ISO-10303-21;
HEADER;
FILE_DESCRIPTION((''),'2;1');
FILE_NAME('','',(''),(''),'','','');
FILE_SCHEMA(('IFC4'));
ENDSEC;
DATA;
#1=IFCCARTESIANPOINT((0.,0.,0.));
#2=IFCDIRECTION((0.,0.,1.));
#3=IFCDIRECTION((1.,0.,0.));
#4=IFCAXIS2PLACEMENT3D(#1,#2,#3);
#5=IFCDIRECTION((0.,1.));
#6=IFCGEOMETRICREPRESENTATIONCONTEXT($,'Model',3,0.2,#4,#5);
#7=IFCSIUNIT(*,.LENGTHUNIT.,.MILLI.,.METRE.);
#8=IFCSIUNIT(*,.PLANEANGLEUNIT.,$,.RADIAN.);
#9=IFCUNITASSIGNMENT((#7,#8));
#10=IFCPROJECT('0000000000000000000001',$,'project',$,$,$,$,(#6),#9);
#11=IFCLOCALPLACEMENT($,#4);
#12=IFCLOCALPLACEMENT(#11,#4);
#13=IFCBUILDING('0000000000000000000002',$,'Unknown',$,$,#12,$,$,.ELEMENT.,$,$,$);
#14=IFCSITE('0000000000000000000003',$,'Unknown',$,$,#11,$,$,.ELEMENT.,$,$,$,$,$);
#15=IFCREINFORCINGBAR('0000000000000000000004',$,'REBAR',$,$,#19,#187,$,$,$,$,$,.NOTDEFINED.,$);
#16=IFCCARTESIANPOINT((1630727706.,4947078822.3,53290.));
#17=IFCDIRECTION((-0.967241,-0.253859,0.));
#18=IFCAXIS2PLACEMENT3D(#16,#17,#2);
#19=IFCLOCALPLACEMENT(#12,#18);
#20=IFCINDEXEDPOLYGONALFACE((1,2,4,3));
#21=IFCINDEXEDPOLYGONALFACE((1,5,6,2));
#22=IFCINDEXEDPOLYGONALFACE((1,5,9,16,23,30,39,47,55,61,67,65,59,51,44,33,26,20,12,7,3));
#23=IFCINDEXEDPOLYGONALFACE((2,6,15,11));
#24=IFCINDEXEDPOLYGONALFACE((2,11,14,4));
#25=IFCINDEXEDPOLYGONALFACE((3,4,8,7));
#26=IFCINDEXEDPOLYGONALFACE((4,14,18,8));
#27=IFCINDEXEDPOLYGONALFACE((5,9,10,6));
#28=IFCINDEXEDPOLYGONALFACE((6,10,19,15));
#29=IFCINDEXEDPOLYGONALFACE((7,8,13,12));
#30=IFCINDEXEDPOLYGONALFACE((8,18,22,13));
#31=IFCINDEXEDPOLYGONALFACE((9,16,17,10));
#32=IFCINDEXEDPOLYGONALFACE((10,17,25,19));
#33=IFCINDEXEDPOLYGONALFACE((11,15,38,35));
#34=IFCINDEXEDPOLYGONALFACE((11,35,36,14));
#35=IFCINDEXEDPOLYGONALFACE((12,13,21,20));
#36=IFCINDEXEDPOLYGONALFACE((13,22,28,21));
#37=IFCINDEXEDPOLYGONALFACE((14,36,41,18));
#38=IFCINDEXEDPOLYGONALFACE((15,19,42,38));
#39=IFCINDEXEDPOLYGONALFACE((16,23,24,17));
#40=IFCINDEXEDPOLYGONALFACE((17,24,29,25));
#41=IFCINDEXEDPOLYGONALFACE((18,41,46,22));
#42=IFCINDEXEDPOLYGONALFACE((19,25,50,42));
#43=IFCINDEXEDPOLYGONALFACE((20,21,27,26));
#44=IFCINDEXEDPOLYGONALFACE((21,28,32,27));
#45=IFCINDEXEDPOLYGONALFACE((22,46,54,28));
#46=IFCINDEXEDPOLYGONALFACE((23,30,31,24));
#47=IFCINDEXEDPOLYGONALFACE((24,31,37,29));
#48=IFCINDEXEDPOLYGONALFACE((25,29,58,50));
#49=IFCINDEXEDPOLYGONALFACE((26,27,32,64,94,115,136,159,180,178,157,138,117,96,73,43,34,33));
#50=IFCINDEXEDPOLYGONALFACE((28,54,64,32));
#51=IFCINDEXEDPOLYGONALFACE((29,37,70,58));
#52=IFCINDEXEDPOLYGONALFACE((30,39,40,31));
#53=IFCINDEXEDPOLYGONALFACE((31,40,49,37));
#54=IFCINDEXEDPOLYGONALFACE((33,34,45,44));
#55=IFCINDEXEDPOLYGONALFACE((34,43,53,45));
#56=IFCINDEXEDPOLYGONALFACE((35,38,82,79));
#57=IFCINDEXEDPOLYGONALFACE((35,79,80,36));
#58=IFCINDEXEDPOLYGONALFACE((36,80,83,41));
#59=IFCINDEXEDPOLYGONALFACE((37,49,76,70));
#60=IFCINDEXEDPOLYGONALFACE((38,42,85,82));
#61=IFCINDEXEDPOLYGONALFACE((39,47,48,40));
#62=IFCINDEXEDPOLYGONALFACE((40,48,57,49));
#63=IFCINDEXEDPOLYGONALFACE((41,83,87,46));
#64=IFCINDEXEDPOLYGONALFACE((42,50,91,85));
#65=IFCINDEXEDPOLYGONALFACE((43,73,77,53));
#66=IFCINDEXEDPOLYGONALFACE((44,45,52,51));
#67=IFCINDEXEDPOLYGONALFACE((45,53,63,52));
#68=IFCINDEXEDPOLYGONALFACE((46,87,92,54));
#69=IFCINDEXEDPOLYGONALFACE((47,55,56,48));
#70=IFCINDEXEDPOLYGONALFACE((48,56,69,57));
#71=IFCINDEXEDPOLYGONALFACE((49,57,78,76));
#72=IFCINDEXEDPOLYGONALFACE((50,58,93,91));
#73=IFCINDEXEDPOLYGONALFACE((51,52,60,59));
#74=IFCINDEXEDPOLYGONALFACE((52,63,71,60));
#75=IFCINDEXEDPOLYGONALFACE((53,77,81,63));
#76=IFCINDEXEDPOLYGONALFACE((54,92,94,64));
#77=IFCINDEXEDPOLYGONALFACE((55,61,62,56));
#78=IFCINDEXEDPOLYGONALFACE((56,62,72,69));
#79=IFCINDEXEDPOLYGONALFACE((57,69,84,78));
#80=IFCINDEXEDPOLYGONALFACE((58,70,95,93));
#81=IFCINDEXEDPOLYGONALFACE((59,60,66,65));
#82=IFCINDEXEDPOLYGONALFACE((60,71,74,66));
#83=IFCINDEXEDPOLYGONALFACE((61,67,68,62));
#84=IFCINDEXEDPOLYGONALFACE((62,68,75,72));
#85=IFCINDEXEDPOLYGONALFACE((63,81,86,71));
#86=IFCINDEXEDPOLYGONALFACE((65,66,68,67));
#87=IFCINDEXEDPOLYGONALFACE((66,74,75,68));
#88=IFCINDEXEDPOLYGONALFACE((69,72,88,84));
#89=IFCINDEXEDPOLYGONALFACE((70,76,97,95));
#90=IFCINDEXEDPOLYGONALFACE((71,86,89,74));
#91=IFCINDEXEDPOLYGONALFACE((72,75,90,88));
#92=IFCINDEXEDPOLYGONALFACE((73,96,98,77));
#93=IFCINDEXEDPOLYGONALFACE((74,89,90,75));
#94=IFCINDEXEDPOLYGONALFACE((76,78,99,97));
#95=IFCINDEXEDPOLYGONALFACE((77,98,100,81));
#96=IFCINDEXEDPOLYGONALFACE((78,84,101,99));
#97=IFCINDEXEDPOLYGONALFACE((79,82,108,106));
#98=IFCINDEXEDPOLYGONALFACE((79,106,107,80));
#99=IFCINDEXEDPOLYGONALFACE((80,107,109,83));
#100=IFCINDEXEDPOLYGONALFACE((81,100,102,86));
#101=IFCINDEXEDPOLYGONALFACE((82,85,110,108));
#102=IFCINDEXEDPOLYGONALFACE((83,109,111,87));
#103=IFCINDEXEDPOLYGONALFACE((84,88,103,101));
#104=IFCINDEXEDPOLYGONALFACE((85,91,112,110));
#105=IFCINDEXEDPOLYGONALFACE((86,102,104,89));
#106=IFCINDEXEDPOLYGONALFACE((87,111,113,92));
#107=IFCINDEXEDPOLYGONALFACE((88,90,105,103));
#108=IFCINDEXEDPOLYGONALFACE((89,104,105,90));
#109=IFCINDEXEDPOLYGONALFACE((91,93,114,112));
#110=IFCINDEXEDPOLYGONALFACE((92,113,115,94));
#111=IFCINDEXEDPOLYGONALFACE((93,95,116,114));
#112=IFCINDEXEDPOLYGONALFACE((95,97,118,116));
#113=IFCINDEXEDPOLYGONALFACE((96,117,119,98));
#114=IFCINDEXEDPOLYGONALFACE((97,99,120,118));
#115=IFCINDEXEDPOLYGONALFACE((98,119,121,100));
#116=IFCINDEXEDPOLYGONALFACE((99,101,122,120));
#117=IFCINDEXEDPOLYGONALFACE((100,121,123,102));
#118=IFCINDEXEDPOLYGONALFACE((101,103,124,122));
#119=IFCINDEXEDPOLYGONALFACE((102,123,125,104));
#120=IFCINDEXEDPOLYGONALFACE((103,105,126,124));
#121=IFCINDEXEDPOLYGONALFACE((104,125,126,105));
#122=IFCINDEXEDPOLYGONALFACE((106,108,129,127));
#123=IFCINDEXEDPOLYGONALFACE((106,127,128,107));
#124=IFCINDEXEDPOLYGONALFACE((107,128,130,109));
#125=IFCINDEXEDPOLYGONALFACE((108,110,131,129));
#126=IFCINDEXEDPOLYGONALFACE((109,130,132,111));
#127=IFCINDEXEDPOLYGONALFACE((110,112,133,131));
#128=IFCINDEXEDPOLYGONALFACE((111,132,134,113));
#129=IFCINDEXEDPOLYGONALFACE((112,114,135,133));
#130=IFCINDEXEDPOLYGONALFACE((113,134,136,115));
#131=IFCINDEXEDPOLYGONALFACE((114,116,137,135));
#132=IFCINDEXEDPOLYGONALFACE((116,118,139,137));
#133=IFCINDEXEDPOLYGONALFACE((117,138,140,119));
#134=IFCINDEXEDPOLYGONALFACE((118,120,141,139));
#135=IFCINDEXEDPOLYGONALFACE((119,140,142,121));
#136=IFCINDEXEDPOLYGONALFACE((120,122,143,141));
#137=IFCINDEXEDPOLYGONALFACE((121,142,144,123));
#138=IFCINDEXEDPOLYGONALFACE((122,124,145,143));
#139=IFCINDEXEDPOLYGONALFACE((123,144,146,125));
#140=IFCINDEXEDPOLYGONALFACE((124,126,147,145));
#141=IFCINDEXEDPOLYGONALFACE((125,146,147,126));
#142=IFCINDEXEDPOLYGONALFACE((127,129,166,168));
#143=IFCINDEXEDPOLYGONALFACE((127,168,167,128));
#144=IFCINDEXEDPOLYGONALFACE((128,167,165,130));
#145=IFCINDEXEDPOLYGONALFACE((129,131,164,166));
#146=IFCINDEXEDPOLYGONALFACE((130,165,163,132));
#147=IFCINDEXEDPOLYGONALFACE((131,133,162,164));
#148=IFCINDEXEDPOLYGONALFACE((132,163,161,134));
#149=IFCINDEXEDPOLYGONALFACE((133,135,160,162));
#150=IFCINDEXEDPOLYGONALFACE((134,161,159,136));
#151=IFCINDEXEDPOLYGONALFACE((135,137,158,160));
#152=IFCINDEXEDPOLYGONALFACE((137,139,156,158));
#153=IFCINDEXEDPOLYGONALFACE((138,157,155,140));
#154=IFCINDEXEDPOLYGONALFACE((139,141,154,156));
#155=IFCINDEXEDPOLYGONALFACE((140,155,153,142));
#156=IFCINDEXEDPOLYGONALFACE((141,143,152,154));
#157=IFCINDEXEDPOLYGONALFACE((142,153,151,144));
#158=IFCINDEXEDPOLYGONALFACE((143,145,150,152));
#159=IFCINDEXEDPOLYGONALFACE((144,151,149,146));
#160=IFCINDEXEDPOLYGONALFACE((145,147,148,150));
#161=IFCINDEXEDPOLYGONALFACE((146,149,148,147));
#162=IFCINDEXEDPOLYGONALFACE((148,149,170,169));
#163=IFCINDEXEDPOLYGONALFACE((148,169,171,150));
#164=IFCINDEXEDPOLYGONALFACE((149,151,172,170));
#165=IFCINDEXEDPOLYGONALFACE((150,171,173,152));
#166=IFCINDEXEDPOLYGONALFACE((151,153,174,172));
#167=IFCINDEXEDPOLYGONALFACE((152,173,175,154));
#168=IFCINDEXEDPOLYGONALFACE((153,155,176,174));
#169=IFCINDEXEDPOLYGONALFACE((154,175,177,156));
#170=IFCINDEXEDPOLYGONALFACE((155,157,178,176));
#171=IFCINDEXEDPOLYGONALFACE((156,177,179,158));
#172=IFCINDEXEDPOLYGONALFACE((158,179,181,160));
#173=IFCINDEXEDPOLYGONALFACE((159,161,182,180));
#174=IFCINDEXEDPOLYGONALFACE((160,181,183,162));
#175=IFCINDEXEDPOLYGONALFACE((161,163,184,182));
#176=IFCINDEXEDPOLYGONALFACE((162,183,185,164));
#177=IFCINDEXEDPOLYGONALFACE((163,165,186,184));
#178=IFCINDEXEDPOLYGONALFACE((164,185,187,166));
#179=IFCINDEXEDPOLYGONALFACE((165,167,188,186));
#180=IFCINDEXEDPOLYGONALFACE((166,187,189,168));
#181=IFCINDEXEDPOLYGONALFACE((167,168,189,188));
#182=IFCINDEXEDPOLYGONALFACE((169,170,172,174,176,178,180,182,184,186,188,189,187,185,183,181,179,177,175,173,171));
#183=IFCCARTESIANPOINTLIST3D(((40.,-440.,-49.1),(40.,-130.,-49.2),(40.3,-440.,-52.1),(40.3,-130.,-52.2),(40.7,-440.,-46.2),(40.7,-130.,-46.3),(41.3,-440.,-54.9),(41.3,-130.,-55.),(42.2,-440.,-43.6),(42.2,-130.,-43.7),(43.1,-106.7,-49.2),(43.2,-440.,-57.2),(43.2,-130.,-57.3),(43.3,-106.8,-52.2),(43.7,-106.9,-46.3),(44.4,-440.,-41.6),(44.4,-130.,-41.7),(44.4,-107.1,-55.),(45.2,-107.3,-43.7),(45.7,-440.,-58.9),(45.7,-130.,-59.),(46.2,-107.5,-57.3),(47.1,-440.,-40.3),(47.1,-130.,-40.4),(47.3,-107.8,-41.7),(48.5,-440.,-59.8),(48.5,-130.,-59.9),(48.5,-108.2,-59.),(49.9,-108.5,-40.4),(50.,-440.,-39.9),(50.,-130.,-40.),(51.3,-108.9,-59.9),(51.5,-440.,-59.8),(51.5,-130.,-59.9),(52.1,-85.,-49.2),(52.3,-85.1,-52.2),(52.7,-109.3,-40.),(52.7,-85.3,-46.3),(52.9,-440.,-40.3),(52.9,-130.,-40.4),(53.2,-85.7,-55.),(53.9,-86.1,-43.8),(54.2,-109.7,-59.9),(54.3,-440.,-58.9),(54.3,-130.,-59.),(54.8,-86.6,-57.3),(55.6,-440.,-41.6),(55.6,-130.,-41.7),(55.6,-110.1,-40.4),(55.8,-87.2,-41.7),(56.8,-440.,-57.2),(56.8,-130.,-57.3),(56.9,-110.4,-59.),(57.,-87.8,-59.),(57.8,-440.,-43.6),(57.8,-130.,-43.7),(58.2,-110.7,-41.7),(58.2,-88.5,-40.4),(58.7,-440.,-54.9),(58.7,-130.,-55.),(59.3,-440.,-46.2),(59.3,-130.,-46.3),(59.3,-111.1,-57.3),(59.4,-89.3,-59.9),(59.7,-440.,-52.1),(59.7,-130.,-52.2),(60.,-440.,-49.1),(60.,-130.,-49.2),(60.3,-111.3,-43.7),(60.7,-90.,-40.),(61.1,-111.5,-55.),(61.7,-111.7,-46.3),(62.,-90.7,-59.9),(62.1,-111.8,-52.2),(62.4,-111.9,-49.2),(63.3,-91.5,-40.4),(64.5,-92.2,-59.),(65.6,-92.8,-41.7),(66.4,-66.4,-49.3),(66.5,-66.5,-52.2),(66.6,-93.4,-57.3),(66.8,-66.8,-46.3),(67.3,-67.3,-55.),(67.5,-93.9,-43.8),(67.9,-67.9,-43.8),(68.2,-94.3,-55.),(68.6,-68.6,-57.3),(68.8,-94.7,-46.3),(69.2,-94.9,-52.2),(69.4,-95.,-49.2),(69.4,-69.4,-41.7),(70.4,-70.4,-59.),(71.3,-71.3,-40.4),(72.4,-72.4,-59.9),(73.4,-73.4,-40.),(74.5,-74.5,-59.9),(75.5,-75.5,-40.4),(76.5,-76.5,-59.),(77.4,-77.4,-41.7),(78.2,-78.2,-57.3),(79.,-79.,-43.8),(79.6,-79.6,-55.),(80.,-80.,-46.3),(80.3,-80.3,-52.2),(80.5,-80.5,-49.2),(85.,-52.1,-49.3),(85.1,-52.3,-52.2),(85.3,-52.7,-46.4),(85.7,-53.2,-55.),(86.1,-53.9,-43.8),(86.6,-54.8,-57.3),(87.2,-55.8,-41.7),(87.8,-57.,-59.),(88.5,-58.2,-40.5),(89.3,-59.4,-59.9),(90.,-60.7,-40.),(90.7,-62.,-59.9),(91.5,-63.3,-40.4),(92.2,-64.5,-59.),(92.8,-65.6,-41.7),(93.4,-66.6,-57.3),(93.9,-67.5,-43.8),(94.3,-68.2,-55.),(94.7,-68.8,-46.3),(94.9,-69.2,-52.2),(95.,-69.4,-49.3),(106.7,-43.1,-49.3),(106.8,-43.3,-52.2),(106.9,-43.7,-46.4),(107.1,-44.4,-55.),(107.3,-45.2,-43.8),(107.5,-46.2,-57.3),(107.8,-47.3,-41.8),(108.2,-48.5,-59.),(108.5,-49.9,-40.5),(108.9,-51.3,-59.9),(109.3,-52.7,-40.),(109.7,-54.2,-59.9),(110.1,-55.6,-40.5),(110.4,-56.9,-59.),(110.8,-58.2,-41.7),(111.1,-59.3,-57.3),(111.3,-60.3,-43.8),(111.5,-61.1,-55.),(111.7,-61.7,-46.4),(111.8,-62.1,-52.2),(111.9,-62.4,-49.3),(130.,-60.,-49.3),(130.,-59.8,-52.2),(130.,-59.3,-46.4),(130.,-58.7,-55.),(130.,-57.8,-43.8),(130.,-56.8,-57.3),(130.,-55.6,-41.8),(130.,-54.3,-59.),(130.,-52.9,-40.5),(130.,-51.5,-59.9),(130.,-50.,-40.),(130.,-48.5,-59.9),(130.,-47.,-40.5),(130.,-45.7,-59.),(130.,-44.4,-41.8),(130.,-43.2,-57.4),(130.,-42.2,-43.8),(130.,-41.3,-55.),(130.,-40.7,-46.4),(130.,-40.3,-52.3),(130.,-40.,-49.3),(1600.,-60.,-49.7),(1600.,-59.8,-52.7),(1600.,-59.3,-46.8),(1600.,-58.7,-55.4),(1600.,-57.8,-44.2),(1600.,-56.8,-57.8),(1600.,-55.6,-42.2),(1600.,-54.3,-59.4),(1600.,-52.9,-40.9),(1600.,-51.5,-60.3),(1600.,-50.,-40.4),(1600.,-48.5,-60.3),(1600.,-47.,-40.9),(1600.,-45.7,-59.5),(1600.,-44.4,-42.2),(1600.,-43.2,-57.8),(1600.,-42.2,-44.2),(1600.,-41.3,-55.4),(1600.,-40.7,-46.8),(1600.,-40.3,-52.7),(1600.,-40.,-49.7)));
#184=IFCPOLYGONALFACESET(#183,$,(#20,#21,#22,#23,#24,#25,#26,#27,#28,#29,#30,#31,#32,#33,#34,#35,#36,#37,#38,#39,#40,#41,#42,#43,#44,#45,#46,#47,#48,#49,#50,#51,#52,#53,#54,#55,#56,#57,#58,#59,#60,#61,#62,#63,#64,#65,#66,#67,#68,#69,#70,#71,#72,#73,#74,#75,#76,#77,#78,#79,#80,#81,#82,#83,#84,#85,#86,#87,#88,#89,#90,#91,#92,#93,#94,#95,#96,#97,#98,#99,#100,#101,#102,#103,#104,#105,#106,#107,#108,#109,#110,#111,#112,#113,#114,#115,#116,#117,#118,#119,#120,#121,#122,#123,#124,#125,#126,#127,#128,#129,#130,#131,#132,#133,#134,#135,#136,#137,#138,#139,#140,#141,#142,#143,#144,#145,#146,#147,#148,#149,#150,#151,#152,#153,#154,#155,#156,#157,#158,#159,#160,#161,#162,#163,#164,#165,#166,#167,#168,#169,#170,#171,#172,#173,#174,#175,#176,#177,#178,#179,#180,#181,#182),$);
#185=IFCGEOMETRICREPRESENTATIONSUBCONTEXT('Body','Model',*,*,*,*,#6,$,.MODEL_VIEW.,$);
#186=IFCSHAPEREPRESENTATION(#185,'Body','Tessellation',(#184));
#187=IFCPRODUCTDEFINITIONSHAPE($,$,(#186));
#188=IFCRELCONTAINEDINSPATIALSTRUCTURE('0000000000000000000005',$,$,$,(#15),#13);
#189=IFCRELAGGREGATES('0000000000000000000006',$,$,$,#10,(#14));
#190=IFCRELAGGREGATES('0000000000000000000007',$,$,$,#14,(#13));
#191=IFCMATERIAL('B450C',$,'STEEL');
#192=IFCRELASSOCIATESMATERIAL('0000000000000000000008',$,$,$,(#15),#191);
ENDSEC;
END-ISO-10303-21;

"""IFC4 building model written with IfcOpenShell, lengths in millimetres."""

from ifc_helpers import new_model, entity, si_unit, direction, frame, origin_with_axes, place, context, subcontext, project, spatial, material, element, save


model = new_model("IFC4")

# Units and contexts
model_context = context("Model", 3, precision=0.2, world=origin_with_axes(), true_north=direction((0.0, 1.0)))
body_context = subcontext(model_context, "Body", "Model", "MODEL_VIEW")
ifc_project = project(units=[si_unit("LENGTHUNIT", "METRE", prefix="MILLI"), si_unit("PLANEANGLEUNIT", "RADIAN")], contexts=[model_context])

# Site, building
site_placement = place(None, origin_with_axes())
site = spatial("IfcSite", under=ifc_project, at=site_placement, Name="Unknown", CompositionType="ELEMENT")
building_placement = place(site_placement, origin_with_axes())
building = spatial("IfcBuilding", under=site, at=building_placement, Name="Unknown", CompositionType="ELEMENT")

# Reinforcing bar
ifc_material = material(Name="B450C", Category="STEEL")
reinforcing_bar_1_placement = place(building_placement, frame((1630727706.0, 4947078822.3, 53290.0), z_axis=(-0.967241, -0.253859, 0.0), x_axis=(0.0, 0.0, 1.0)))
element("IfcReinforcingBar", 1, at=reinforcing_bar_1_placement, inside=building, material=ifc_material, Name="REBAR", PredefinedType="NOTDEFINED", context=body_context, shape_type="AdvancedSweptSolid", body=[
    entity("IfcSweptDiskSolid", entity("IfcIndexedPolyCurve", entity("IfcCartesianPointList3D", [[50.0, -440.0, -49.9], [50.0, -130.0, -50.0], [73.4, -73.4, -50.0], [130.0, -50.0, -50.0], [1600.0, -50.0, -50.4]]), [entity("IfcLineIndex", [1, 2]), entity("IfcArcIndex", [2, 3, 4]), entity("IfcLineIndex", [4, 5])]), 10.0),
])

save(model, "model.ifc")
